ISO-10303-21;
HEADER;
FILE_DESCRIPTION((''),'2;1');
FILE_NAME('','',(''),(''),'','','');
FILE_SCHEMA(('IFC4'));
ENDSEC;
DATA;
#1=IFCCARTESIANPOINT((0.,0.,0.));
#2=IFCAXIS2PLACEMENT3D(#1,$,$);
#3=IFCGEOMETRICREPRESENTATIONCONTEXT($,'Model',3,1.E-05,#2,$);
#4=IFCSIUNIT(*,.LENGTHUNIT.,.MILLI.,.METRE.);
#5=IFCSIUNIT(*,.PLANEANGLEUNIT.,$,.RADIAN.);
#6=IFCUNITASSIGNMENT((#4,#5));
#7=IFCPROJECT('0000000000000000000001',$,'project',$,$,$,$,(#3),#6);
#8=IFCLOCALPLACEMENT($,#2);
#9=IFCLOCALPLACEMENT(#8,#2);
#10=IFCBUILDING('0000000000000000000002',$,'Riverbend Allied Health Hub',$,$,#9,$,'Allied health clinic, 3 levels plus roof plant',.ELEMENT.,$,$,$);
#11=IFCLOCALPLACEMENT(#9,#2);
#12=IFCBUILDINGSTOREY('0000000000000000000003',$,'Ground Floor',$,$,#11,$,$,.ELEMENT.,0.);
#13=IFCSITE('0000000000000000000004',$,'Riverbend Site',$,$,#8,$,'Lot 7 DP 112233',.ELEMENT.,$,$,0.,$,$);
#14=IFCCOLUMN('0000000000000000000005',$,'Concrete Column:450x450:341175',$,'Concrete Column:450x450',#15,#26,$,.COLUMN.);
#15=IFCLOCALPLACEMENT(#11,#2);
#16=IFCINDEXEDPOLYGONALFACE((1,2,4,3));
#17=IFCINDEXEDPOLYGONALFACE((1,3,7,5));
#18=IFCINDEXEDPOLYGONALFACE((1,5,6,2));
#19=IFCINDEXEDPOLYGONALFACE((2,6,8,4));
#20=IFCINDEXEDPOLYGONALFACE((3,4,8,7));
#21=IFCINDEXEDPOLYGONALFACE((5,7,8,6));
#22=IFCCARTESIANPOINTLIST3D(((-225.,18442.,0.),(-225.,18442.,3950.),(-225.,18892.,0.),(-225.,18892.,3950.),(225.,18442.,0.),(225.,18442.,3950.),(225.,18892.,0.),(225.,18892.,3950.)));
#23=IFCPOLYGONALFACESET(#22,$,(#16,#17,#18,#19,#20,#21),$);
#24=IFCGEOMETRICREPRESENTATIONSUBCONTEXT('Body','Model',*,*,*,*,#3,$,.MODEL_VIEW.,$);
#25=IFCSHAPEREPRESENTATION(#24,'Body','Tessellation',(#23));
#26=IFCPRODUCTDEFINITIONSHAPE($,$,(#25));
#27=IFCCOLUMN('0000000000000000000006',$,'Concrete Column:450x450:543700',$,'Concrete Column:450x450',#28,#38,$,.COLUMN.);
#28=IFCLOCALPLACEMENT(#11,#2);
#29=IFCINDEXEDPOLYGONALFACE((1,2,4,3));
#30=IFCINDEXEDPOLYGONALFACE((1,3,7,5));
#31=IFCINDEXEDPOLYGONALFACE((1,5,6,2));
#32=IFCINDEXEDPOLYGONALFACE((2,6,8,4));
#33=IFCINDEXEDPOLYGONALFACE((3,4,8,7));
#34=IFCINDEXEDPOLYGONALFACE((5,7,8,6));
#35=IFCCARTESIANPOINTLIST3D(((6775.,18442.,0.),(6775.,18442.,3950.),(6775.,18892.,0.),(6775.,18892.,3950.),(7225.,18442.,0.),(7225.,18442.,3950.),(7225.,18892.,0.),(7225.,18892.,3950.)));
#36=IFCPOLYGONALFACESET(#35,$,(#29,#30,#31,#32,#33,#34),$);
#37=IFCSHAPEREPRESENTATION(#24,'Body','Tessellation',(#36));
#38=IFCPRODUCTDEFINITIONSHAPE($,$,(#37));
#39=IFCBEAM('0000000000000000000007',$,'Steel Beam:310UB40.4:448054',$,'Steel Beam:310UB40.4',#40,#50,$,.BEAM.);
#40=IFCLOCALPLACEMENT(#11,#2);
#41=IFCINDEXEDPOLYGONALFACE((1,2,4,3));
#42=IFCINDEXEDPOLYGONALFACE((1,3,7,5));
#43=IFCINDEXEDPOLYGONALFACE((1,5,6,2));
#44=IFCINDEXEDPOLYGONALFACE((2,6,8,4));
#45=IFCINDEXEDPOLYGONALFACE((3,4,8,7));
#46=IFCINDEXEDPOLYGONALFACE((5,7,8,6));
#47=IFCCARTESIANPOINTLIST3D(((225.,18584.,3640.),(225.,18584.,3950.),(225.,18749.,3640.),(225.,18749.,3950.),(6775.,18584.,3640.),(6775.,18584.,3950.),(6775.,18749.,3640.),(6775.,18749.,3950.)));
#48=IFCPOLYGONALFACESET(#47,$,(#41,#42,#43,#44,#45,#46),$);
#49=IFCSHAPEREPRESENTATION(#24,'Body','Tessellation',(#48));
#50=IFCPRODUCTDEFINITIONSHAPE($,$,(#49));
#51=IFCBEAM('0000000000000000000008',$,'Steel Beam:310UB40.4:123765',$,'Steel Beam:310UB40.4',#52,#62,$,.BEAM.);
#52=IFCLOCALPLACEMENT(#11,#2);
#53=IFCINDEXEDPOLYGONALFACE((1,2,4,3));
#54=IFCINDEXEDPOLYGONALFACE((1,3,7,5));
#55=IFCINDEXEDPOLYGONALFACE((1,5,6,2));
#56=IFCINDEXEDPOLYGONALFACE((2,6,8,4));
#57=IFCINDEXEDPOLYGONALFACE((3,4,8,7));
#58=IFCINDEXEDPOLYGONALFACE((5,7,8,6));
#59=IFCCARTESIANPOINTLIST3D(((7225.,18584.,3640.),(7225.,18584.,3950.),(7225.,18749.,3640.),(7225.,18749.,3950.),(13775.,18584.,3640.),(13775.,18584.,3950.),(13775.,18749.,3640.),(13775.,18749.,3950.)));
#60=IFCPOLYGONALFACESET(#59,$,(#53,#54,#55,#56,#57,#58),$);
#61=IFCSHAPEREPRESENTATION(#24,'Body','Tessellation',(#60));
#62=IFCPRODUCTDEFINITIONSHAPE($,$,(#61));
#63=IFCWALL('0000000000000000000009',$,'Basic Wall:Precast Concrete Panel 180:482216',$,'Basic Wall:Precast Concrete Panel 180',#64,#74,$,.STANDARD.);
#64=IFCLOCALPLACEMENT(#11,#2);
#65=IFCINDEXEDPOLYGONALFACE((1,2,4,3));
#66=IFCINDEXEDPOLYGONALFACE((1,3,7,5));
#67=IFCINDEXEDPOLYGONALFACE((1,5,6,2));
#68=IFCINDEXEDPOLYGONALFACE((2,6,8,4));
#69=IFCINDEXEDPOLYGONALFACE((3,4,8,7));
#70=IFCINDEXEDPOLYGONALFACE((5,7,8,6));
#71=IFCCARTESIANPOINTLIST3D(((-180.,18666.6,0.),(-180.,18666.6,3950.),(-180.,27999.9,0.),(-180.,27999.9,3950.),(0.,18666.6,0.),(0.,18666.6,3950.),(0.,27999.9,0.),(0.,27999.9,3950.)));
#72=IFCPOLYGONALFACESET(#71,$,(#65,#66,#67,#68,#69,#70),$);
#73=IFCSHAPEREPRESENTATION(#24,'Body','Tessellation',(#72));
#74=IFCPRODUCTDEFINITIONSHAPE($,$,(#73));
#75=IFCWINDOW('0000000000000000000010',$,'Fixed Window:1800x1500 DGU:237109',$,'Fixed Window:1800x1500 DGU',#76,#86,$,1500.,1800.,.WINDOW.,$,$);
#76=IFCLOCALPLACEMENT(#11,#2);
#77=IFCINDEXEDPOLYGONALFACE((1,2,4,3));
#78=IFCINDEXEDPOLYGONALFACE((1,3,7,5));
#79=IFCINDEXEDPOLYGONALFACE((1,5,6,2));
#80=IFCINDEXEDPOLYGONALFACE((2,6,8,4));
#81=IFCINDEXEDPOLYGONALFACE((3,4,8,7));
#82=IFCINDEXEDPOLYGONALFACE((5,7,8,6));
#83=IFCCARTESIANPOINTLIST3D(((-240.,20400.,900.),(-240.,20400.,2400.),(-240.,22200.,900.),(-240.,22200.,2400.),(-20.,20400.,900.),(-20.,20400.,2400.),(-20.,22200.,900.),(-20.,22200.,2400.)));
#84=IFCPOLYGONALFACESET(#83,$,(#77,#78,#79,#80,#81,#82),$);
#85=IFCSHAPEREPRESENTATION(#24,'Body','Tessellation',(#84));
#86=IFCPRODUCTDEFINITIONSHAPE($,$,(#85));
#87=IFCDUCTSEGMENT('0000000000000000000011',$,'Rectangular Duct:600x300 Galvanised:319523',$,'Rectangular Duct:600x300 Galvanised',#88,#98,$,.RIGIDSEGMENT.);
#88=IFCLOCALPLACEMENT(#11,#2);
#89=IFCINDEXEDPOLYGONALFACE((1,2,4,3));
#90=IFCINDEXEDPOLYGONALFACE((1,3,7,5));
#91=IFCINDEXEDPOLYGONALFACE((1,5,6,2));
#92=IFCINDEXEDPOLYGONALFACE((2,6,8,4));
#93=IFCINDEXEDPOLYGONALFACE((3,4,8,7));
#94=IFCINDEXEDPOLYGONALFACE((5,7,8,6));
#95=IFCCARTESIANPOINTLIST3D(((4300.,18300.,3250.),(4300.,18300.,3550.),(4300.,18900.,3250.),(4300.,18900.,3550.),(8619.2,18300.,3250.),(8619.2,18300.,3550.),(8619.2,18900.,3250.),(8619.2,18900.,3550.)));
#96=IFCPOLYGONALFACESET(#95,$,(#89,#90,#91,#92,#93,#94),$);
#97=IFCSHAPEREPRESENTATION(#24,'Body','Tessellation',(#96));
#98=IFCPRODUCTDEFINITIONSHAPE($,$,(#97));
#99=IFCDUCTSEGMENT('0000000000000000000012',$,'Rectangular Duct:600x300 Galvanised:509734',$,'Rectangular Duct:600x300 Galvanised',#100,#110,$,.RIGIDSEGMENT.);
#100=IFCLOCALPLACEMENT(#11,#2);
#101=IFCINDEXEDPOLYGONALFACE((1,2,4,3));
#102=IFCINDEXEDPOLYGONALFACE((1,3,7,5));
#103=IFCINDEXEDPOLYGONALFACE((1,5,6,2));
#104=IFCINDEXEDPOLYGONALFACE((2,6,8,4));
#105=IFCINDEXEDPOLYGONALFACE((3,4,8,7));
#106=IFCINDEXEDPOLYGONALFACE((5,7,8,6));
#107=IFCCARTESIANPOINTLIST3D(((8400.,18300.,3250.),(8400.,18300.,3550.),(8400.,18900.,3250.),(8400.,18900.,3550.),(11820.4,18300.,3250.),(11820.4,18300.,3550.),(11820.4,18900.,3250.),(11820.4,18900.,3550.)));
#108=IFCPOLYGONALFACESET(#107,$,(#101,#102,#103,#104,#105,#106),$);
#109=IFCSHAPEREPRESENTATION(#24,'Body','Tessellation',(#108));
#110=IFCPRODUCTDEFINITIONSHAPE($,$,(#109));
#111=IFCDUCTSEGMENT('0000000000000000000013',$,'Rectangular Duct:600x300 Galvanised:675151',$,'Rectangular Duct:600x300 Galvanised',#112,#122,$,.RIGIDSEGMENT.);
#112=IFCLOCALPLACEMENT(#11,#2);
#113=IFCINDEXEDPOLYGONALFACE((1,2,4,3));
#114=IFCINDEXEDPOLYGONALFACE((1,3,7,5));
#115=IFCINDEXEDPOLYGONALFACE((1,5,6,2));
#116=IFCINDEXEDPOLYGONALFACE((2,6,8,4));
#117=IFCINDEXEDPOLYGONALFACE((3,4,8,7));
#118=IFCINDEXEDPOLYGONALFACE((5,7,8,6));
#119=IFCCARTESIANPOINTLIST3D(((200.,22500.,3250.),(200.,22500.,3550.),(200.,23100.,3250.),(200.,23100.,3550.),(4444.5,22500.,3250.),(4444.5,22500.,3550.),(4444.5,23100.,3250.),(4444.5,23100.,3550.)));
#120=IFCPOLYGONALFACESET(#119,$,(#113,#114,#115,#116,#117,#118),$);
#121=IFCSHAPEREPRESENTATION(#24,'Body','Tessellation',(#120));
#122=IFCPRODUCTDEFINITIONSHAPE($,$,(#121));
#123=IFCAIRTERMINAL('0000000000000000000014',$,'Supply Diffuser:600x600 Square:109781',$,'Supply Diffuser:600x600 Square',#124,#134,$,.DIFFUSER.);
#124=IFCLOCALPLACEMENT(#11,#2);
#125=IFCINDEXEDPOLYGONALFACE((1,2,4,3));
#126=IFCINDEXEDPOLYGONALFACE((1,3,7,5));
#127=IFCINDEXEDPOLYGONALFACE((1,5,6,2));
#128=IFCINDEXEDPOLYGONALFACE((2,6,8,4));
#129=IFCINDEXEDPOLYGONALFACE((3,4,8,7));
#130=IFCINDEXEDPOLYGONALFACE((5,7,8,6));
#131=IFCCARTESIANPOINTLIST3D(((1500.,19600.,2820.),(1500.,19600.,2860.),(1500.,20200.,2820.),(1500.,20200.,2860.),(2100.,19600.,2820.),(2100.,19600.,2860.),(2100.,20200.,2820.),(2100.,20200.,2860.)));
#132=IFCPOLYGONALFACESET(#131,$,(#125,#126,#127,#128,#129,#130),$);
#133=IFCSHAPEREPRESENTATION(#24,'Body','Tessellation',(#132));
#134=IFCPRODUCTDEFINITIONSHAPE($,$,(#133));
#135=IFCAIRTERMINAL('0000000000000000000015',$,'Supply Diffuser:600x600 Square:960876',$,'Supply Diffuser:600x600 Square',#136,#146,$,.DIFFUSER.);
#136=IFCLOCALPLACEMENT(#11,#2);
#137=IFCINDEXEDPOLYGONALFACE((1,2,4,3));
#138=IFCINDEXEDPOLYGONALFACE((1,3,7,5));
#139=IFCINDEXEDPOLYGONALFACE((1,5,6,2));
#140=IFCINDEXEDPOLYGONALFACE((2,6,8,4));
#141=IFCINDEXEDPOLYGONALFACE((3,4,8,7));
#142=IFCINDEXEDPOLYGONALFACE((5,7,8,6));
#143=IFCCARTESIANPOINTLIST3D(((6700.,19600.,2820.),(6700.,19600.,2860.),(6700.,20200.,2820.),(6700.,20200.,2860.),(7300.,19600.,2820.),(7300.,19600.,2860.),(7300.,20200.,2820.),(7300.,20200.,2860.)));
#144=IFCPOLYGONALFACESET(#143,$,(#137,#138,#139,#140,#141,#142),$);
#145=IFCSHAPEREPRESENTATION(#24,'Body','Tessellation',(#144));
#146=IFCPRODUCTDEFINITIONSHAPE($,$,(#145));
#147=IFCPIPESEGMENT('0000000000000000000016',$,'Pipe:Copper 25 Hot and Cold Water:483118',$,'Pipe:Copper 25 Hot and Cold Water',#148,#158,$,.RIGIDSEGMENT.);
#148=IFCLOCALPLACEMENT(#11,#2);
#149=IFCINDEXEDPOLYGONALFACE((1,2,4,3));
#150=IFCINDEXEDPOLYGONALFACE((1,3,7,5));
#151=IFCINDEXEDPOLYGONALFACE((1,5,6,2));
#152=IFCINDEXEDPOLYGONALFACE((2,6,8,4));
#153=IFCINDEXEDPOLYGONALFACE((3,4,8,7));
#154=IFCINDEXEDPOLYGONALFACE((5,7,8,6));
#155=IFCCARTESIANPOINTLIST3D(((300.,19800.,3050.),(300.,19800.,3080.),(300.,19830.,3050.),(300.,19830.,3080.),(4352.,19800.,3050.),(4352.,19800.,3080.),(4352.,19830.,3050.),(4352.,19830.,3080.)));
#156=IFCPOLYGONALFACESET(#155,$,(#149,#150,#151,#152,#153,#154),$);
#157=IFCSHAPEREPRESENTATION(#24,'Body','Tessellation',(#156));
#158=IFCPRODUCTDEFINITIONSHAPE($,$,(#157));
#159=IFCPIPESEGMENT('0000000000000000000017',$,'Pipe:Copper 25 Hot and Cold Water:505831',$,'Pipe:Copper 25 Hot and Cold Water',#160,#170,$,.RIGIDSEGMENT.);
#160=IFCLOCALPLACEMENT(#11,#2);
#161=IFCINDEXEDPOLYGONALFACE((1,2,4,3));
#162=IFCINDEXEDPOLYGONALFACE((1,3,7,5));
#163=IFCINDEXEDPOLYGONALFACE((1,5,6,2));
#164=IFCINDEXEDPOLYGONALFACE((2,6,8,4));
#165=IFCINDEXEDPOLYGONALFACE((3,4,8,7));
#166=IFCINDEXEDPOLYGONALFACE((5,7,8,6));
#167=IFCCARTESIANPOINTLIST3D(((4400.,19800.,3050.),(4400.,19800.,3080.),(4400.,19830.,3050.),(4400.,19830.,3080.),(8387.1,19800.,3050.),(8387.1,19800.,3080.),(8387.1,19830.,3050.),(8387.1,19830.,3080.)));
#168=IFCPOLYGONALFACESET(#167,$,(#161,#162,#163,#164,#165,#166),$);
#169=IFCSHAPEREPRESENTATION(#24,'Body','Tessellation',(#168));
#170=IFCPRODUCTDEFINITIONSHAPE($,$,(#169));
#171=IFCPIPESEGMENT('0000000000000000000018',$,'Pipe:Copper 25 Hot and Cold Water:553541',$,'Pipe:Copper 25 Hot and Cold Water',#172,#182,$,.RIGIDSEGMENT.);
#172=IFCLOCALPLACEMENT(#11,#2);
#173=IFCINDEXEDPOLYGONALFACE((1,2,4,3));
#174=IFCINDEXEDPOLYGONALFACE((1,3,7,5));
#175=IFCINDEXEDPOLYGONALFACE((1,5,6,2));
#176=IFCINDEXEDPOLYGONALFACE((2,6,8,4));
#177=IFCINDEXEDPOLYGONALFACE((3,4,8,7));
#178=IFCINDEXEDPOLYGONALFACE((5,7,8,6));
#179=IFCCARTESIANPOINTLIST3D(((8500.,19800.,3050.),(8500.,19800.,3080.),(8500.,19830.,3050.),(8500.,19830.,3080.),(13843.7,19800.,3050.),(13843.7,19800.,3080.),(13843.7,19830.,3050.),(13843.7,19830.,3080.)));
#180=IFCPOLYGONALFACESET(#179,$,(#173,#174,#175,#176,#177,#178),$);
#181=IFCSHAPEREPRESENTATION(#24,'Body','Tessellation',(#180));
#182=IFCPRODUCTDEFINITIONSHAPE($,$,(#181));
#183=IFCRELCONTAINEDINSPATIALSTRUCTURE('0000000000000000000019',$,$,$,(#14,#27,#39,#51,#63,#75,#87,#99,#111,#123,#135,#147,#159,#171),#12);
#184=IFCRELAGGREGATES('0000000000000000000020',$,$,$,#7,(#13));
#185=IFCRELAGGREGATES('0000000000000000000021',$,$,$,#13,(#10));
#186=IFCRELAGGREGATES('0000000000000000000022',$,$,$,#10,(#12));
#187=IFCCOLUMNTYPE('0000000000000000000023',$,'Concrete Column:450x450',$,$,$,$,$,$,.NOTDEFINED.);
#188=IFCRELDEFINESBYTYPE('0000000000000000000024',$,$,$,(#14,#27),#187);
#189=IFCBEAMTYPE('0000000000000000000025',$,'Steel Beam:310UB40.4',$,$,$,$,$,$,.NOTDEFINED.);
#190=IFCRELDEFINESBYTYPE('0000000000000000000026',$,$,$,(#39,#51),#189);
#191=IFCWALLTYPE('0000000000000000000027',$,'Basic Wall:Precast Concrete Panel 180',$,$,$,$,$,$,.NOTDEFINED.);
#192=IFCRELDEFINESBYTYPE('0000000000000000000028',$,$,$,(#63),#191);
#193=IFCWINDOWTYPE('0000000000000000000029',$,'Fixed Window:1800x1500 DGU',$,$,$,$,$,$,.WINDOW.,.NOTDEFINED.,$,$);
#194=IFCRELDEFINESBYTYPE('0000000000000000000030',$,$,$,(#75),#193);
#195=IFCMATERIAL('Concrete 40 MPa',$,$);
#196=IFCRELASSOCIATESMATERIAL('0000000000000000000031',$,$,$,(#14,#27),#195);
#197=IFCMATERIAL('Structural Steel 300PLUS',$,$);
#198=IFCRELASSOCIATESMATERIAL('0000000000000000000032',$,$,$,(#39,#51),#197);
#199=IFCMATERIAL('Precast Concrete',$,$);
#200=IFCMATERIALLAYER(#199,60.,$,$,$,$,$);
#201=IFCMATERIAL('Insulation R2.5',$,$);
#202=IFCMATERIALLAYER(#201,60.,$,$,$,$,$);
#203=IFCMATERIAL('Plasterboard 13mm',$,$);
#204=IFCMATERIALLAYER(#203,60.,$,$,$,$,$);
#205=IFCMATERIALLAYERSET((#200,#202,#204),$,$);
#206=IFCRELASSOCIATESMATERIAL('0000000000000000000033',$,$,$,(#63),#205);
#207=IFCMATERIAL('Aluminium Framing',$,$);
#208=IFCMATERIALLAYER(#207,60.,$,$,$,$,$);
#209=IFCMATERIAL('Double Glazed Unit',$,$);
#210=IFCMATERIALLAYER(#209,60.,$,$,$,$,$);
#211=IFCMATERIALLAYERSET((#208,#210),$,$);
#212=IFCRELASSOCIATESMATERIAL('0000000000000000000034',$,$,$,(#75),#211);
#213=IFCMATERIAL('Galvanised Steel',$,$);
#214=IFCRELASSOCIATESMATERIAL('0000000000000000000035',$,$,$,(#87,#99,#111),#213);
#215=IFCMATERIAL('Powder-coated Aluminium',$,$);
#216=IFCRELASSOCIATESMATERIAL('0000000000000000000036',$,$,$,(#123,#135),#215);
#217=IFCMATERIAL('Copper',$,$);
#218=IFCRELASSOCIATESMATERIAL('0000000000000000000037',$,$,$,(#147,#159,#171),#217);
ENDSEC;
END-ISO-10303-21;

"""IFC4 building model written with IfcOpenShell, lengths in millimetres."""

from ifc_helpers import new_model, si_unit, frame, frame_2d, origin, place, context, subcontext, project, spatial, rectangle, extrude, material, layer, layer_set, layer_usage, type_object, element, save


model = new_model("IFC4")

# Units and contexts
model_context = context("Model", 3, precision=1e-05, world=origin())
body_context = subcontext(model_context, "Body", "Model", "MODEL_VIEW")
ifc_project = project(units=[si_unit("LENGTHUNIT", "METRE", prefix="MILLI"), si_unit("PLANEANGLEUNIT", "RADIAN")], contexts=[model_context])

# Site, building, storey
site_placement = place(None, origin())
site = spatial("IfcSite", under=ifc_project, at=site_placement, Name="Riverbend Site", LongName="Lot 7 DP 112233", CompositionType="ELEMENT", RefElevation=0.0)
building_placement = place(site_placement, origin())
building = spatial("IfcBuilding", under=site, at=building_placement, Name="Riverbend Allied Health Hub", LongName="Allied health clinic, 3 levels plus roof plant", CompositionType="ELEMENT")
storey_placement = place(building_placement, origin())
storey = spatial("IfcBuildingStorey", under=building, at=storey_placement, Name="Ground Floor", CompositionType="ELEMENT", Elevation=0.0)

# Columns
ifc_material_1 = material(Name="Concrete 40 MPa")
column_type = type_object("IfcColumnType", Name="Concrete Column:450x450", PredefinedType="NOTDEFINED")
for number, where, name in (
    (1, (-225.0, 18442.0, 0.0), "Concrete Column:450x450:341175"),
    (2, (6775.0, 18442.0, 0.0), "Concrete Column:450x450:543700"),
):
    element("IfcColumn", number, at=place(storey_placement, frame(where)), inside=storey, type_object=column_type, material=ifc_material_1, Name=name, ObjectType="Concrete Column:450x450", PredefinedType="COLUMN", context=body_context, shape_type="SweptSolid", body=[
        extrude(rectangle(XDim=450.0, YDim=450.0, at=frame_2d((225.0, 225.0))), origin(), (0.0, 0.0, 1.0), 3950.0),
    ])

# Beams
ifc_material_2 = material(Name="Structural Steel 300PLUS")
beam_type = type_object("IfcBeamType", Name="Steel Beam:310UB40.4", PredefinedType="NOTDEFINED")
for number, where, name in (
    (3, (225.0, 18584.0, 3640.0), "Steel Beam:310UB40.4:448054"),
    (4, (7225.0, 18584.0, 3640.0), "Steel Beam:310UB40.4:123765"),
):
    element("IfcBeam", number, at=place(storey_placement, frame(where)), inside=storey, type_object=beam_type, material=ifc_material_2, Name=name, ObjectType="Steel Beam:310UB40.4", PredefinedType="BEAM", context=body_context, shape_type="SweptSolid", body=[
        extrude(rectangle(XDim=6550.0, YDim=165.0, at=frame_2d((3275.0, 82.5))), origin(), (0.0, 0.0, 1.0), 310.0),
    ])

# Wall
ifc_material_3 = material(Name="Precast Concrete")
ifc_layer_1 = layer(ifc_material_3, 60.0)
ifc_material_4 = material(Name="Insulation R2.5")
ifc_layer_2 = layer(ifc_material_4, 60.0)
ifc_material_5 = material(Name="Plasterboard 13mm")
ifc_layer_3 = layer(ifc_material_5, 60.0)
ifc_layer_set_1 = layer_set([ifc_layer_1, ifc_layer_2, ifc_layer_3])
ifc_layer_usage_1 = layer_usage(ifc_layer_set_1, "AXIS2", "POSITIVE", 0.0)
wall_type = type_object("IfcWallType", Name="Basic Wall:Precast Concrete Panel 180", PredefinedType="NOTDEFINED")
wall_placement = place(storey_placement, frame((0.0, 18666.6, 0.0), z_axis=(0.0, 0.0, 1.0), x_axis=(0.0, 1.0, 0.0)))
element("IfcWall", 5, at=wall_placement, inside=storey, type_object=wall_type, material=ifc_layer_usage_1, Name="Basic Wall:Precast Concrete Panel 180:482216", ObjectType="Basic Wall:Precast Concrete Panel 180", PredefinedType="STANDARD", context=body_context, shape_type="SweptSolid", body=[
    extrude(rectangle(XDim=9333.3, YDim=180.0, at=frame_2d((4666.6, 90.0))), origin(), (0.0, 0.0, 1.0), 3950.0),
])

# Window
ifc_material_6 = material(Name="Aluminium Framing")
ifc_layer_4 = layer(ifc_material_6, 60.0)
ifc_material_7 = material(Name="Double Glazed Unit")
ifc_layer_5 = layer(ifc_material_7, 60.0)
ifc_layer_set_2 = layer_set([ifc_layer_4, ifc_layer_5])
ifc_layer_usage_2 = layer_usage(ifc_layer_set_2, "AXIS2", "POSITIVE", 0.0)
window_type = type_object("IfcWindowType", Name="Fixed Window:1800x1500 DGU", PartitioningType="NOTDEFINED", PredefinedType="WINDOW")
window_placement = place(storey_placement, frame((-20.0, 20400.0, 900.0), z_axis=(0.0, 0.0, 1.0), x_axis=(0.0, 1.0, 0.0)))
element("IfcWindow", 6, at=window_placement, inside=storey, type_object=window_type, material=ifc_layer_usage_2, Name="Fixed Window:1800x1500 DGU:237109", ObjectType="Fixed Window:1800x1500 DGU", OverallHeight=1500.0, OverallWidth=1800.0, PredefinedType="WINDOW", context=body_context, shape_type="SweptSolid", body=[
    extrude(rectangle(XDim=1800.0, YDim=220.0, at=frame_2d((900.0, 110.0))), origin(), (0.0, 0.0, 1.0), 1500.0),
])

# Duct segments
ifc_material_8 = material(Name="Galvanised Steel")
duct_segment_1_placement = place(storey_placement, frame((4300.0, 18300.0, 3250.0)))
element("IfcDuctSegment", 7, at=duct_segment_1_placement, inside=storey, material=ifc_material_8, Name="Rectangular Duct:600x300 Galvanised:319523", ObjectType="Rectangular Duct:600x300 Galvanised", PredefinedType="RIGIDSEGMENT", context=body_context, shape_type="SweptSolid", body=[
    extrude(rectangle(XDim=4319.2, YDim=600.0, at=frame_2d((2159.6, 300.0))), origin(), (0.0, 0.0, 1.0), 300.0),
])
duct_segment_2_placement = place(storey_placement, frame((8400.0, 18300.0, 3250.0)))
element("IfcDuctSegment", 8, at=duct_segment_2_placement, inside=storey, material=ifc_material_8, Name="Rectangular Duct:600x300 Galvanised:509734", ObjectType="Rectangular Duct:600x300 Galvanised", PredefinedType="RIGIDSEGMENT", context=body_context, shape_type="SweptSolid", body=[
    extrude(rectangle(XDim=3420.4, YDim=600.0, at=frame_2d((1710.2, 300.0))), origin(), (0.0, 0.0, 1.0), 300.0),
])
duct_segment_3_placement = place(storey_placement, frame((200.0, 22500.0, 3250.0)))
element("IfcDuctSegment", 9, at=duct_segment_3_placement, inside=storey, material=ifc_material_8, Name="Rectangular Duct:600x300 Galvanised:675151", ObjectType="Rectangular Duct:600x300 Galvanised", PredefinedType="RIGIDSEGMENT", context=body_context, shape_type="SweptSolid", body=[
    extrude(rectangle(XDim=4244.5, YDim=600.0, at=frame_2d((2122.3, 300.0))), origin(), (0.0, 0.0, 1.0), 300.0),
])

# Air terminals
ifc_material_9 = material(Name="Powder-coated Aluminium")
for number, where, name in (
    (10, (1500.0, 19600.0, 2820.0), "Supply Diffuser:600x600 Square:109781"),
    (11, (6700.0, 19600.0, 2820.0), "Supply Diffuser:600x600 Square:960876"),
):
    element("IfcAirTerminal", number, at=place(storey_placement, frame(where)), inside=storey, material=ifc_material_9, Name=name, ObjectType="Supply Diffuser:600x600 Square", PredefinedType="DIFFUSER", context=body_context, shape_type="SweptSolid", body=[
        extrude(rectangle(XDim=600.0, YDim=600.0, at=frame_2d((300.0, 300.0))), origin(), (0.0, 0.0, 1.0), 40.0),
    ])

# Pipe segments
ifc_material_10 = material(Name="Copper")
pipe_segment_1_placement = place(storey_placement, frame((300.0, 19800.0, 3050.0)))
element("IfcPipeSegment", 12, at=pipe_segment_1_placement, inside=storey, material=ifc_material_10, Name="Pipe:Copper 25 Hot and Cold Water:483118", ObjectType="Pipe:Copper 25 Hot and Cold Water", PredefinedType="RIGIDSEGMENT", context=body_context, shape_type="SweptSolid", body=[
    extrude(rectangle(XDim=4052.0, YDim=30.0, at=frame_2d((2026.0, 15.0))), origin(), (0.0, 0.0, 1.0), 30.0),
])
pipe_segment_2_placement = place(storey_placement, frame((4400.0, 19800.0, 3050.0)))
element("IfcPipeSegment", 13, at=pipe_segment_2_placement, inside=storey, material=ifc_material_10, Name="Pipe:Copper 25 Hot and Cold Water:505831", ObjectType="Pipe:Copper 25 Hot and Cold Water", PredefinedType="RIGIDSEGMENT", context=body_context, shape_type="SweptSolid", body=[
    extrude(rectangle(XDim=3987.1, YDim=30.0, at=frame_2d((1993.6, 15.0))), origin(), (0.0, 0.0, 1.0), 30.0),
])
pipe_segment_3_placement = place(storey_placement, frame((8500.0, 19800.0, 3050.0)))
element("IfcPipeSegment", 14, at=pipe_segment_3_placement, inside=storey, material=ifc_material_10, Name="Pipe:Copper 25 Hot and Cold Water:553541", ObjectType="Pipe:Copper 25 Hot and Cold Water", PredefinedType="RIGIDSEGMENT", context=body_context, shape_type="SweptSolid", body=[
    extrude(rectangle(XDim=5343.7, YDim=30.0, at=frame_2d((2671.8, 15.0))), origin(), (0.0, 0.0, 1.0), 30.0),
])

save(model, "model.ifc")
